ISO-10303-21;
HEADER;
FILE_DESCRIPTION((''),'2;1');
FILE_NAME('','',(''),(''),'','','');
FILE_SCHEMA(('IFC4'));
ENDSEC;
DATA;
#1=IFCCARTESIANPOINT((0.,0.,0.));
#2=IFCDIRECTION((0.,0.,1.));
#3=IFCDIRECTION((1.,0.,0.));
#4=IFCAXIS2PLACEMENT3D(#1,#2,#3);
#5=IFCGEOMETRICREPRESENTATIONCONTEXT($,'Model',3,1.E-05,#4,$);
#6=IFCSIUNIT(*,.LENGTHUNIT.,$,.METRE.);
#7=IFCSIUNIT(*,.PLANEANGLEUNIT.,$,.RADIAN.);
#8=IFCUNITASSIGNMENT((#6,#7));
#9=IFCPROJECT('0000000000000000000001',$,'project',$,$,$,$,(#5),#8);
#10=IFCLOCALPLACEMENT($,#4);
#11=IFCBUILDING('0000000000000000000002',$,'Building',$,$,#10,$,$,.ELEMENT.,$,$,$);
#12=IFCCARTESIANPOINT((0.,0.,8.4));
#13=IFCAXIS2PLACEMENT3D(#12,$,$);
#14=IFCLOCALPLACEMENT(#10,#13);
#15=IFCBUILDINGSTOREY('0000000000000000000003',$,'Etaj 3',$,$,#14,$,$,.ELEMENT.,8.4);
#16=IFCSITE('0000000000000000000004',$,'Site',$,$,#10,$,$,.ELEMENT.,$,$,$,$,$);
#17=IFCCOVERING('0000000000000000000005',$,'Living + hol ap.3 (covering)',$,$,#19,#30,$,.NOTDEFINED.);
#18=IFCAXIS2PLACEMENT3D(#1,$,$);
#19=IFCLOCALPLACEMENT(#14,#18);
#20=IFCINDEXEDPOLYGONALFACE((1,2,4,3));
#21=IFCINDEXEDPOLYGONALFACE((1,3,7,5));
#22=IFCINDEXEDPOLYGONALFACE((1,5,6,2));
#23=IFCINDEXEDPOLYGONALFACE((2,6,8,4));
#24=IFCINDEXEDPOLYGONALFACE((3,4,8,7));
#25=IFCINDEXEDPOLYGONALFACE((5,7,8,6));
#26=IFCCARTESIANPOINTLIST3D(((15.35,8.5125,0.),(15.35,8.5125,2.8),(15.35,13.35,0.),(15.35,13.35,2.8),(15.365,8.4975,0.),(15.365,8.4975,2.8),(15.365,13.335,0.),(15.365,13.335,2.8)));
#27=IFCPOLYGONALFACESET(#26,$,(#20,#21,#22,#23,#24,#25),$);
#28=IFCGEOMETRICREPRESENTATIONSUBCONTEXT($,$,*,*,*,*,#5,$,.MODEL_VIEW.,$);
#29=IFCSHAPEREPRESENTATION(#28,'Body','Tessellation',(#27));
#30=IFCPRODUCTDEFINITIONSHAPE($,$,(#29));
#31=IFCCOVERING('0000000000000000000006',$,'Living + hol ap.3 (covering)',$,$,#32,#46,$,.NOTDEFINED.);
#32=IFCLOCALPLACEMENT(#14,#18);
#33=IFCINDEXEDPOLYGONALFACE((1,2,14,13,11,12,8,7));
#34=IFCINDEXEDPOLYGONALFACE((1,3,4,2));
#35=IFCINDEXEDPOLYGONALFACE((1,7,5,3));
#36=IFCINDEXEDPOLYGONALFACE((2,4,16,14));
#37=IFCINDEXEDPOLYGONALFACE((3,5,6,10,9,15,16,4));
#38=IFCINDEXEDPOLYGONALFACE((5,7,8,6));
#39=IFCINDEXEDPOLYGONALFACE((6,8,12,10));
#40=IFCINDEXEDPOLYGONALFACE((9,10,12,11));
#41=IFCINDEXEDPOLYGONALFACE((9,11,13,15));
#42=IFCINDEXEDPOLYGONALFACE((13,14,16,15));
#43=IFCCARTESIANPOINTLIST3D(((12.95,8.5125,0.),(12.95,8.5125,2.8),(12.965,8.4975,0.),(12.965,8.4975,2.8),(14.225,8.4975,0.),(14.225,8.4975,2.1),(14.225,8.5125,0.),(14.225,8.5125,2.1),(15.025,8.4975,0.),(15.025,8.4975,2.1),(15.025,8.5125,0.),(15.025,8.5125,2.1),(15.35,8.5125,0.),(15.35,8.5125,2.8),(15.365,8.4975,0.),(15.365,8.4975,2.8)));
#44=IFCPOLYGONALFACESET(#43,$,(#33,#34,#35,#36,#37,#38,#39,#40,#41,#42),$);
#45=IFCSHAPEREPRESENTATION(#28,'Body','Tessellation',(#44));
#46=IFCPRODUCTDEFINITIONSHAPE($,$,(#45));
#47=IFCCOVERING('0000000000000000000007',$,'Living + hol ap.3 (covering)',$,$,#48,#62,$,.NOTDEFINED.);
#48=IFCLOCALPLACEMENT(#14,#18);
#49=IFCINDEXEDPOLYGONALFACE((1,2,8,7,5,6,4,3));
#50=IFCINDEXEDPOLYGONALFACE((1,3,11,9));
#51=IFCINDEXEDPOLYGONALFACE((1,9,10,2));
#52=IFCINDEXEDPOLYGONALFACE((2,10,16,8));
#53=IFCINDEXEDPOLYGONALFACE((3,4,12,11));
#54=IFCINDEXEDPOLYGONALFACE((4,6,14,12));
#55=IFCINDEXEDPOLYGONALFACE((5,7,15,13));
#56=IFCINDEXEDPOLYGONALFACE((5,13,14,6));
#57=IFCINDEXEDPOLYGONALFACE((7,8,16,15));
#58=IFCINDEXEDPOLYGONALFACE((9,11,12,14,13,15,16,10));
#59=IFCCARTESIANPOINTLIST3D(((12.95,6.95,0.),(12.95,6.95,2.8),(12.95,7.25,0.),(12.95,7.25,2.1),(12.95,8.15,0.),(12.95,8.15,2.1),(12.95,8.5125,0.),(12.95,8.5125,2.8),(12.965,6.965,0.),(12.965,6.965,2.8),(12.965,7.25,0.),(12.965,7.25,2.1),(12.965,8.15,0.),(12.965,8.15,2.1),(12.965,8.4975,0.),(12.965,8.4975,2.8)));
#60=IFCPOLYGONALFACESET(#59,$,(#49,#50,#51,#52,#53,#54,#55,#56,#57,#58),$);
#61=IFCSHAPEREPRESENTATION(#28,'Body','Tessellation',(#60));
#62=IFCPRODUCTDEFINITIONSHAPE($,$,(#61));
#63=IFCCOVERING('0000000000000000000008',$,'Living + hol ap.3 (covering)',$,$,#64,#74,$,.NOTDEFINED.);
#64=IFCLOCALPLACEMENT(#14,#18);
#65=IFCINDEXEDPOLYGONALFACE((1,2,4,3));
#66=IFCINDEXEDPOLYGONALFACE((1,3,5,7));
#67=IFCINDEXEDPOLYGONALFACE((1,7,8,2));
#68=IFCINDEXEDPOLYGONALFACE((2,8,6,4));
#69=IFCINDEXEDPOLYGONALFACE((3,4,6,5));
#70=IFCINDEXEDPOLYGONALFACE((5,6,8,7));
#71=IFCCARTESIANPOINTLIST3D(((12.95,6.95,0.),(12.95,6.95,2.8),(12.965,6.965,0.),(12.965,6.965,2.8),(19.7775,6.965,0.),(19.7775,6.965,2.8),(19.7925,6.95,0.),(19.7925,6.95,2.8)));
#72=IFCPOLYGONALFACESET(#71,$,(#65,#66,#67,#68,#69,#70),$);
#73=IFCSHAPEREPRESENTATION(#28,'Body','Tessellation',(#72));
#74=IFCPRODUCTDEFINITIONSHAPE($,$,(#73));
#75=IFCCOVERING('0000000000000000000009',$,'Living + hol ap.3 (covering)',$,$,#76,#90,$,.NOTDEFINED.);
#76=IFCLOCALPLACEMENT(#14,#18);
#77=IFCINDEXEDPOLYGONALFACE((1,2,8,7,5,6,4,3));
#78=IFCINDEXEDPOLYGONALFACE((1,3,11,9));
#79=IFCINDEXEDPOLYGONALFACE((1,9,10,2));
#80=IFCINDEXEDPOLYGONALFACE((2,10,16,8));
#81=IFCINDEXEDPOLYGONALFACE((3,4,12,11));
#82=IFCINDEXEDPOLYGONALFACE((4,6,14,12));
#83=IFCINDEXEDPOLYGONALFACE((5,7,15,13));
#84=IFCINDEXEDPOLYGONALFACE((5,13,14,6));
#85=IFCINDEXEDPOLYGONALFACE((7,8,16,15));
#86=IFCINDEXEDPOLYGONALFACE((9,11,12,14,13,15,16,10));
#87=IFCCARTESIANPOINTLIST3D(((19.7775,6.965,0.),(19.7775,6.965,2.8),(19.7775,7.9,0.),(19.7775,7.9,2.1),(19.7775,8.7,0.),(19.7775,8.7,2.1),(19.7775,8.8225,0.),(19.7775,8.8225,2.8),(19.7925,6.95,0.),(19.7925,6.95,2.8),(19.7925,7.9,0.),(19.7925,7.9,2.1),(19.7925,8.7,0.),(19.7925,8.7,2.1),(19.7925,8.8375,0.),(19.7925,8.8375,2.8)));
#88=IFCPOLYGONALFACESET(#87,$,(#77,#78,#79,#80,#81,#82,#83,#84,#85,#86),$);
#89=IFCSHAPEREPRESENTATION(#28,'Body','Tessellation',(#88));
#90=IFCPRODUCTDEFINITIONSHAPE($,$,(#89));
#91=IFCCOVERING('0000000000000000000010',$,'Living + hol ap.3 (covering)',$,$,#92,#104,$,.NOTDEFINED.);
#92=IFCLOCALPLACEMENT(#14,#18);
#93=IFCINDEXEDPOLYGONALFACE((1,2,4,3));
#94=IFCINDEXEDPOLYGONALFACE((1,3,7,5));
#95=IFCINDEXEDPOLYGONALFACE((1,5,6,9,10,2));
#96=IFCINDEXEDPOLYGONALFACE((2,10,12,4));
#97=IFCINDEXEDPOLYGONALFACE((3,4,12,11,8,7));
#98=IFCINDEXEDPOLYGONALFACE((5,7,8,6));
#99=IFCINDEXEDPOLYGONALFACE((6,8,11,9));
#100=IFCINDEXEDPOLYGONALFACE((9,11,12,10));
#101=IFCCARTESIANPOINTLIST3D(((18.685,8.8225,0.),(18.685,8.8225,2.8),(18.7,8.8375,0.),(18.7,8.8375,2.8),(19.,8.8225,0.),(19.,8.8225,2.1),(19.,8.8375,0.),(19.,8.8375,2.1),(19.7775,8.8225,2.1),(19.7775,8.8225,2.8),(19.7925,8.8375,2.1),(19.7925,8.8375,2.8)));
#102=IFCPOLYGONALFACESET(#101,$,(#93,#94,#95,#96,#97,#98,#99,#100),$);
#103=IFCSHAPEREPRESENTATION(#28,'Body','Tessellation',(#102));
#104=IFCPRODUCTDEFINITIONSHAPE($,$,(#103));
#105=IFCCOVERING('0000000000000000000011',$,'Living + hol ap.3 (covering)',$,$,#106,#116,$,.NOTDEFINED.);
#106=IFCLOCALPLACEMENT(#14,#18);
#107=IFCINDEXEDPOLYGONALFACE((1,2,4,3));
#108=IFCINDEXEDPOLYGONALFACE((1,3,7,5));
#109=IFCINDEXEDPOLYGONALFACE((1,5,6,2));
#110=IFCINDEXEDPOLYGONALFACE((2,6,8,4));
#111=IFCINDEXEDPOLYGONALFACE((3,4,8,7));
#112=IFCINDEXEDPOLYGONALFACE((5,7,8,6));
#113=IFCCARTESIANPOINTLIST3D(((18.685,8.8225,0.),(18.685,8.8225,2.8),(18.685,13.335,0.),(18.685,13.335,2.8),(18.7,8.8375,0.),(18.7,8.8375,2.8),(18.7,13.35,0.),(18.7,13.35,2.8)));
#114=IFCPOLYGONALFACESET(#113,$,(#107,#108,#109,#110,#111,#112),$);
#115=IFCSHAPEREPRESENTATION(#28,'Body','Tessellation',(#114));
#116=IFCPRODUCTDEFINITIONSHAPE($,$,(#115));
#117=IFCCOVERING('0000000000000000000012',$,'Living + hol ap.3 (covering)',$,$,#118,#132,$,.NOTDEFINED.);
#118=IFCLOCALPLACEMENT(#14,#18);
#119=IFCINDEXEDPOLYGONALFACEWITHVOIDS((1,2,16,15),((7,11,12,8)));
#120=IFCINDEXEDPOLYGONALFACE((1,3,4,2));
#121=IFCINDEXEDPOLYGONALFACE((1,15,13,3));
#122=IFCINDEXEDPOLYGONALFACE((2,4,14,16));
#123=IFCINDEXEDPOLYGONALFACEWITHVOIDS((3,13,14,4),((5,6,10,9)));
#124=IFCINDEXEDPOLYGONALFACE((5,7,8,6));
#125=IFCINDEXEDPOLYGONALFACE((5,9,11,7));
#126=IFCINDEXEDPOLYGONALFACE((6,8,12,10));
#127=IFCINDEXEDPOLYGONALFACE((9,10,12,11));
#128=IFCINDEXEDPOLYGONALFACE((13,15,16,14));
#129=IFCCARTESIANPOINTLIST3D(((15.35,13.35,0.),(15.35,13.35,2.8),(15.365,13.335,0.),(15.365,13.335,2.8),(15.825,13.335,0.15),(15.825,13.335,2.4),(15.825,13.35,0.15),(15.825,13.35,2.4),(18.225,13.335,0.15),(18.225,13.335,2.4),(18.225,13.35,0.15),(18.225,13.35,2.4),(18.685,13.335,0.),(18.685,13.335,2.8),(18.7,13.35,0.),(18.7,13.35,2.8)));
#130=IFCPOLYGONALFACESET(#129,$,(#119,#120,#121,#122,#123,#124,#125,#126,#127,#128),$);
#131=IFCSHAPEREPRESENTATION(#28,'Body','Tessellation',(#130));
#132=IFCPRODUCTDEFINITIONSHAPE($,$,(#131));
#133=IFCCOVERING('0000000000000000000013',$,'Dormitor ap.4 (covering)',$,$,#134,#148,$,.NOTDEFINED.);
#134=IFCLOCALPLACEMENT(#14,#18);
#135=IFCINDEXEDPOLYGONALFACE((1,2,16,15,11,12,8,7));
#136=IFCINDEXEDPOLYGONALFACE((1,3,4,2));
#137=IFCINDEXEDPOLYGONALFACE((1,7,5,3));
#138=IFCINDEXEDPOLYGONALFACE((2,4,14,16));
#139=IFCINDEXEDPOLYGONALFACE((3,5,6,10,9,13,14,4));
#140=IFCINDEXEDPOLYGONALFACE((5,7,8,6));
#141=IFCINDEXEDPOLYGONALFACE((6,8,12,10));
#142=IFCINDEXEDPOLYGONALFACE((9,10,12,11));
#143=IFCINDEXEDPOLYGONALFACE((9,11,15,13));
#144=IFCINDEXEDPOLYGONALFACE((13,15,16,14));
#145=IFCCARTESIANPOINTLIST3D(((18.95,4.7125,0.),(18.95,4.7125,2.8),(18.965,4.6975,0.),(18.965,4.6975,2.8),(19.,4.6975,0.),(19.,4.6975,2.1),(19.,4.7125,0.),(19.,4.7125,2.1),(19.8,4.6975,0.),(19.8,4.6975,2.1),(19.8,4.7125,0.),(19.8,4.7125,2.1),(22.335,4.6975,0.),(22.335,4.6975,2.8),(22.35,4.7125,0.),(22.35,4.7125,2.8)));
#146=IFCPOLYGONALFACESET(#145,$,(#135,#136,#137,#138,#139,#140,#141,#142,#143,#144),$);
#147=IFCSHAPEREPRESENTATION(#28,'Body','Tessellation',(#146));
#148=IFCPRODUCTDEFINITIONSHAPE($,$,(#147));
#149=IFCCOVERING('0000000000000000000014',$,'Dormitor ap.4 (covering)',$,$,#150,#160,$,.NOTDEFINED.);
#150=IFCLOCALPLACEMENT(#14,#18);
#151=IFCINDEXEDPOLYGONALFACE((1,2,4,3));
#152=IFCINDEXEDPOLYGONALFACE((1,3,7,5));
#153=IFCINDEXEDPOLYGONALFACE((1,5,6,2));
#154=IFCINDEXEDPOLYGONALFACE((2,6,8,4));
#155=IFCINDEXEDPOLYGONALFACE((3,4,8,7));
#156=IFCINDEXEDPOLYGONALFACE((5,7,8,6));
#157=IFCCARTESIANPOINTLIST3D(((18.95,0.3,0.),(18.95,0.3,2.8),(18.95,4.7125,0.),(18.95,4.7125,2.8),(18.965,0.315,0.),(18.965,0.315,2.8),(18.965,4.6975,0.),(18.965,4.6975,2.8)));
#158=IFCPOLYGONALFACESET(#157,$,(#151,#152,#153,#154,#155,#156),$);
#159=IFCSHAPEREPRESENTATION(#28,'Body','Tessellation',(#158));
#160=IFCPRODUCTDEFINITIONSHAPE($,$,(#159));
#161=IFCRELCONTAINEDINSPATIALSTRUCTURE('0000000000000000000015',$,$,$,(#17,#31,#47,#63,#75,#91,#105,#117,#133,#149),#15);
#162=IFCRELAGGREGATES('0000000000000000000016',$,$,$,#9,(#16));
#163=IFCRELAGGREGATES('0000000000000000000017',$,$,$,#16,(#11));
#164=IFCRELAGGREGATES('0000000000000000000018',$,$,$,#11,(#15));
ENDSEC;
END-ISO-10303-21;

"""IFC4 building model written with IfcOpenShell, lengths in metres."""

from ifc_helpers import new_model, si_unit, frame, origin, origin_with_axes, origin_2d, place, context, subcontext, project, spatial, polyline, rectangle, outline, extrude, element, save


model = new_model("IFC4")

# Units and contexts
model_context = context("Model", 3, precision=1e-05, world=origin_with_axes())
sub_context = subcontext(model_context, None, None, "MODEL_VIEW")
ifc_project = project(units=[si_unit("LENGTHUNIT", "METRE"), si_unit("PLANEANGLEUNIT", "RADIAN")], contexts=[model_context])

# Site, building, storey
placement = place(None, origin_with_axes())
site = spatial("IfcSite", under=ifc_project, at=placement, Name="Site", CompositionType="ELEMENT")
building = spatial("IfcBuilding", under=site, at=placement, Name="Building", CompositionType="ELEMENT")
storey_placement = place(placement, frame((0.0, 0.0, 8.4)))
storey = spatial("IfcBuildingStorey", under=building, at=storey_placement, Name="Etaj 3", CompositionType="ELEMENT", Elevation=8.4)

# Covering
covering_1_placement = place(storey_placement, origin_with_axes())
element("IfcCovering", 1, at=covering_1_placement, inside=storey, Name="Living + hol ap.3 (covering)", PredefinedType="NOTDEFINED", context=sub_context, shape_type="SweptSolid", body=[
    extrude(outline(polyline([(15.35, 13.35), (15.35, 8.5125), (15.365, 8.4975), (15.365, 13.335), (15.35, 13.35)])), origin(), (0.0, 0.0, 1.0), 2.8),
])

# Coverings, openings
covering_2_placement = place(storey_placement, origin_with_axes())
covering_2 = element("IfcCovering", 2, at=covering_2_placement, inside=storey, Name="Living + hol ap.3 (covering)", PredefinedType="NOTDEFINED", context=sub_context, shape_type="SweptSolid", body=[
    extrude(outline(polyline([(15.35, 8.5125), (12.95, 8.5125), (12.965, 8.4975), (15.365, 8.4975), (15.35, 8.5125)])), origin(), (0.0, 0.0, 1.0), 2.8),
])
opening_1_placement = place(covering_2_placement, frame((14.625, 8.8275, 0.0), z_axis=(0.0, -1.0, 0.0), x_axis=(1.0, 0.0, 0.0)))
element("IfcOpeningElement", 3, at=opening_1_placement, cuts=covering_2, PredefinedType="OPENING", context=sub_context, shape_type="SweptSolid", body=[
    extrude(rectangle(XDim=0.8, YDim=2.1, at=origin_2d()), frame((0.0, 1.05, 0.0)), (0.0, 0.0, 1.0), 0.38),
])
covering_3_placement = place(storey_placement, origin_with_axes())
covering_3 = element("IfcCovering", 4, at=covering_3_placement, inside=storey, Name="Living + hol ap.3 (covering)", PredefinedType="NOTDEFINED", context=sub_context, shape_type="SweptSolid", body=[
    extrude(outline(polyline([(12.95, 8.5125), (12.95, 6.95), (12.965, 6.965), (12.965, 8.4975), (12.95, 8.5125)])), origin(), (0.0, 0.0, 1.0), 2.8),
])
opening_2_placement = place(covering_3_placement, frame((12.635, 7.7, 0.0), z_axis=(1.0, 0.0, 0.0), x_axis=(0.0, 1.0, 0.0)))
element("IfcOpeningElement", 5, at=opening_2_placement, cuts=covering_3, PredefinedType="OPENING", context=sub_context, shape_type="SweptSolid", body=[
    extrude(rectangle(XDim=0.9, YDim=2.1, at=origin_2d()), frame((0.0, 1.05, 0.0)), (0.0, 0.0, 1.0), 0.38),
])

# Covering
covering_4_placement = place(storey_placement, origin_with_axes())
element("IfcCovering", 6, at=covering_4_placement, inside=storey, Name="Living + hol ap.3 (covering)", PredefinedType="NOTDEFINED", context=sub_context, shape_type="SweptSolid", body=[
    extrude(outline(polyline([(12.95, 6.95), (19.7925, 6.95), (19.7775, 6.965), (12.965, 6.965), (12.95, 6.95)])), origin(), (0.0, 0.0, 1.0), 2.8),
])

# Coverings, openings
covering_5_placement = place(storey_placement, origin_with_axes())
covering_5 = element("IfcCovering", 7, at=covering_5_placement, inside=storey, Name="Living + hol ap.3 (covering)", PredefinedType="NOTDEFINED", context=sub_context, shape_type="SweptSolid", body=[
    extrude(outline(polyline([(19.7925, 6.95), (19.7925, 8.8375), (19.7775, 8.8225), (19.7775, 6.965), (19.7925, 6.95)])), origin(), (0.0, 0.0, 1.0), 2.8),
])
opening_3_placement = place(covering_5_placement, frame((19.7275, 8.3, 0.0), z_axis=(1.0, 0.0, 0.0), x_axis=(0.0, 1.0, 0.0)))
element("IfcOpeningElement", 8, at=opening_3_placement, cuts=covering_5, PredefinedType="OPENING", context=sub_context, shape_type="SweptSolid", body=[
    extrude(rectangle(XDim=0.8, YDim=2.1, at=origin_2d()), frame((0.0, 1.05, 0.0)), (0.0, 0.0, 1.0), 0.38),
])
covering_6_placement = place(storey_placement, origin_with_axes())
covering_6 = element("IfcCovering", 9, at=covering_6_placement, inside=storey, Name="Living + hol ap.3 (covering)", PredefinedType="NOTDEFINED", context=sub_context, shape_type="SweptSolid", body=[
    extrude(outline(polyline([(19.7925, 8.8375), (18.7, 8.8375), (18.685, 8.8225), (19.7775, 8.8225), (19.7925, 8.8375)])), origin(), (0.0, 0.0, 1.0), 2.8),
])
opening_4_placement = place(covering_6_placement, frame((19.4, 9.1525, 0.0), z_axis=(0.0, -1.0, 0.0), x_axis=(1.0, 0.0, 0.0)))
element("IfcOpeningElement", 10, at=opening_4_placement, cuts=covering_6, PredefinedType="OPENING", context=sub_context, shape_type="SweptSolid", body=[
    extrude(rectangle(XDim=0.8, YDim=2.1, at=origin_2d()), frame((0.0, 1.05, 0.0)), (0.0, 0.0, 1.0), 0.38),
])

# Covering
covering_7_placement = place(storey_placement, origin_with_axes())
element("IfcCovering", 11, at=covering_7_placement, inside=storey, Name="Living + hol ap.3 (covering)", PredefinedType="NOTDEFINED", context=sub_context, shape_type="SweptSolid", body=[
    extrude(outline(polyline([(18.7, 8.8375), (18.7, 13.35), (18.685, 13.335), (18.685, 8.8225), (18.7, 8.8375)])), origin(), (0.0, 0.0, 1.0), 2.8),
])

# Coverings, openings
covering_8_placement = place(storey_placement, origin_with_axes())
covering_8 = element("IfcCovering", 12, at=covering_8_placement, inside=storey, Name="Living + hol ap.3 (covering)", PredefinedType="NOTDEFINED", context=sub_context, shape_type="SweptSolid", body=[
    extrude(outline(polyline([(18.7, 13.35), (15.35, 13.35), (15.365, 13.335), (18.685, 13.335), (18.7, 13.35)])), origin(), (0.0, 0.0, 1.0), 2.8),
])
opening_5_placement = place(covering_8_placement, frame((17.025, 13.665, 0.15), z_axis=(0.0, -1.0, 0.0), x_axis=(1.0, 0.0, 0.0)))
element("IfcOpeningElement", 13, at=opening_5_placement, cuts=covering_8, PredefinedType="OPENING", context=sub_context, shape_type="SweptSolid", body=[
    extrude(rectangle(XDim=2.4, YDim=2.25, at=origin_2d()), frame((0.0, 1.125, 0.0)), (0.0, 0.0, 1.0), 0.38),
])
covering_9_placement = place(storey_placement, origin_with_axes())
covering_9 = element("IfcCovering", 14, at=covering_9_placement, inside=storey, Name="Dormitor ap.4 (covering)", PredefinedType="NOTDEFINED", context=sub_context, shape_type="SweptSolid", body=[
    extrude(outline(polyline([(22.35, 4.7125), (18.95, 4.7125), (18.965, 4.6975), (22.335, 4.6975), (22.35, 4.7125)])), origin(), (0.0, 0.0, 1.0), 2.8),
])
opening_6_placement = place(covering_9_placement, frame((19.4, 5.0275, 0.0), z_axis=(0.0, -1.0, 0.0), x_axis=(1.0, 0.0, 0.0)))
element("IfcOpeningElement", 15, at=opening_6_placement, cuts=covering_9, PredefinedType="OPENING", context=sub_context, shape_type="SweptSolid", body=[
    extrude(rectangle(XDim=0.8, YDim=2.1, at=origin_2d()), frame((0.0, 1.05, 0.0)), (0.0, 0.0, 1.0), 0.38),
])

# Covering
covering_10_placement = place(storey_placement, origin_with_axes())
element("IfcCovering", 16, at=covering_10_placement, inside=storey, Name="Dormitor ap.4 (covering)", PredefinedType="NOTDEFINED", context=sub_context, shape_type="SweptSolid", body=[
    extrude(outline(polyline([(18.95, 4.7125), (18.95, 0.3), (18.965, 0.315), (18.965, 4.6975), (18.95, 4.7125)])), origin(), (0.0, 0.0, 1.0), 2.8),
])

save(model, "model.ifc")
